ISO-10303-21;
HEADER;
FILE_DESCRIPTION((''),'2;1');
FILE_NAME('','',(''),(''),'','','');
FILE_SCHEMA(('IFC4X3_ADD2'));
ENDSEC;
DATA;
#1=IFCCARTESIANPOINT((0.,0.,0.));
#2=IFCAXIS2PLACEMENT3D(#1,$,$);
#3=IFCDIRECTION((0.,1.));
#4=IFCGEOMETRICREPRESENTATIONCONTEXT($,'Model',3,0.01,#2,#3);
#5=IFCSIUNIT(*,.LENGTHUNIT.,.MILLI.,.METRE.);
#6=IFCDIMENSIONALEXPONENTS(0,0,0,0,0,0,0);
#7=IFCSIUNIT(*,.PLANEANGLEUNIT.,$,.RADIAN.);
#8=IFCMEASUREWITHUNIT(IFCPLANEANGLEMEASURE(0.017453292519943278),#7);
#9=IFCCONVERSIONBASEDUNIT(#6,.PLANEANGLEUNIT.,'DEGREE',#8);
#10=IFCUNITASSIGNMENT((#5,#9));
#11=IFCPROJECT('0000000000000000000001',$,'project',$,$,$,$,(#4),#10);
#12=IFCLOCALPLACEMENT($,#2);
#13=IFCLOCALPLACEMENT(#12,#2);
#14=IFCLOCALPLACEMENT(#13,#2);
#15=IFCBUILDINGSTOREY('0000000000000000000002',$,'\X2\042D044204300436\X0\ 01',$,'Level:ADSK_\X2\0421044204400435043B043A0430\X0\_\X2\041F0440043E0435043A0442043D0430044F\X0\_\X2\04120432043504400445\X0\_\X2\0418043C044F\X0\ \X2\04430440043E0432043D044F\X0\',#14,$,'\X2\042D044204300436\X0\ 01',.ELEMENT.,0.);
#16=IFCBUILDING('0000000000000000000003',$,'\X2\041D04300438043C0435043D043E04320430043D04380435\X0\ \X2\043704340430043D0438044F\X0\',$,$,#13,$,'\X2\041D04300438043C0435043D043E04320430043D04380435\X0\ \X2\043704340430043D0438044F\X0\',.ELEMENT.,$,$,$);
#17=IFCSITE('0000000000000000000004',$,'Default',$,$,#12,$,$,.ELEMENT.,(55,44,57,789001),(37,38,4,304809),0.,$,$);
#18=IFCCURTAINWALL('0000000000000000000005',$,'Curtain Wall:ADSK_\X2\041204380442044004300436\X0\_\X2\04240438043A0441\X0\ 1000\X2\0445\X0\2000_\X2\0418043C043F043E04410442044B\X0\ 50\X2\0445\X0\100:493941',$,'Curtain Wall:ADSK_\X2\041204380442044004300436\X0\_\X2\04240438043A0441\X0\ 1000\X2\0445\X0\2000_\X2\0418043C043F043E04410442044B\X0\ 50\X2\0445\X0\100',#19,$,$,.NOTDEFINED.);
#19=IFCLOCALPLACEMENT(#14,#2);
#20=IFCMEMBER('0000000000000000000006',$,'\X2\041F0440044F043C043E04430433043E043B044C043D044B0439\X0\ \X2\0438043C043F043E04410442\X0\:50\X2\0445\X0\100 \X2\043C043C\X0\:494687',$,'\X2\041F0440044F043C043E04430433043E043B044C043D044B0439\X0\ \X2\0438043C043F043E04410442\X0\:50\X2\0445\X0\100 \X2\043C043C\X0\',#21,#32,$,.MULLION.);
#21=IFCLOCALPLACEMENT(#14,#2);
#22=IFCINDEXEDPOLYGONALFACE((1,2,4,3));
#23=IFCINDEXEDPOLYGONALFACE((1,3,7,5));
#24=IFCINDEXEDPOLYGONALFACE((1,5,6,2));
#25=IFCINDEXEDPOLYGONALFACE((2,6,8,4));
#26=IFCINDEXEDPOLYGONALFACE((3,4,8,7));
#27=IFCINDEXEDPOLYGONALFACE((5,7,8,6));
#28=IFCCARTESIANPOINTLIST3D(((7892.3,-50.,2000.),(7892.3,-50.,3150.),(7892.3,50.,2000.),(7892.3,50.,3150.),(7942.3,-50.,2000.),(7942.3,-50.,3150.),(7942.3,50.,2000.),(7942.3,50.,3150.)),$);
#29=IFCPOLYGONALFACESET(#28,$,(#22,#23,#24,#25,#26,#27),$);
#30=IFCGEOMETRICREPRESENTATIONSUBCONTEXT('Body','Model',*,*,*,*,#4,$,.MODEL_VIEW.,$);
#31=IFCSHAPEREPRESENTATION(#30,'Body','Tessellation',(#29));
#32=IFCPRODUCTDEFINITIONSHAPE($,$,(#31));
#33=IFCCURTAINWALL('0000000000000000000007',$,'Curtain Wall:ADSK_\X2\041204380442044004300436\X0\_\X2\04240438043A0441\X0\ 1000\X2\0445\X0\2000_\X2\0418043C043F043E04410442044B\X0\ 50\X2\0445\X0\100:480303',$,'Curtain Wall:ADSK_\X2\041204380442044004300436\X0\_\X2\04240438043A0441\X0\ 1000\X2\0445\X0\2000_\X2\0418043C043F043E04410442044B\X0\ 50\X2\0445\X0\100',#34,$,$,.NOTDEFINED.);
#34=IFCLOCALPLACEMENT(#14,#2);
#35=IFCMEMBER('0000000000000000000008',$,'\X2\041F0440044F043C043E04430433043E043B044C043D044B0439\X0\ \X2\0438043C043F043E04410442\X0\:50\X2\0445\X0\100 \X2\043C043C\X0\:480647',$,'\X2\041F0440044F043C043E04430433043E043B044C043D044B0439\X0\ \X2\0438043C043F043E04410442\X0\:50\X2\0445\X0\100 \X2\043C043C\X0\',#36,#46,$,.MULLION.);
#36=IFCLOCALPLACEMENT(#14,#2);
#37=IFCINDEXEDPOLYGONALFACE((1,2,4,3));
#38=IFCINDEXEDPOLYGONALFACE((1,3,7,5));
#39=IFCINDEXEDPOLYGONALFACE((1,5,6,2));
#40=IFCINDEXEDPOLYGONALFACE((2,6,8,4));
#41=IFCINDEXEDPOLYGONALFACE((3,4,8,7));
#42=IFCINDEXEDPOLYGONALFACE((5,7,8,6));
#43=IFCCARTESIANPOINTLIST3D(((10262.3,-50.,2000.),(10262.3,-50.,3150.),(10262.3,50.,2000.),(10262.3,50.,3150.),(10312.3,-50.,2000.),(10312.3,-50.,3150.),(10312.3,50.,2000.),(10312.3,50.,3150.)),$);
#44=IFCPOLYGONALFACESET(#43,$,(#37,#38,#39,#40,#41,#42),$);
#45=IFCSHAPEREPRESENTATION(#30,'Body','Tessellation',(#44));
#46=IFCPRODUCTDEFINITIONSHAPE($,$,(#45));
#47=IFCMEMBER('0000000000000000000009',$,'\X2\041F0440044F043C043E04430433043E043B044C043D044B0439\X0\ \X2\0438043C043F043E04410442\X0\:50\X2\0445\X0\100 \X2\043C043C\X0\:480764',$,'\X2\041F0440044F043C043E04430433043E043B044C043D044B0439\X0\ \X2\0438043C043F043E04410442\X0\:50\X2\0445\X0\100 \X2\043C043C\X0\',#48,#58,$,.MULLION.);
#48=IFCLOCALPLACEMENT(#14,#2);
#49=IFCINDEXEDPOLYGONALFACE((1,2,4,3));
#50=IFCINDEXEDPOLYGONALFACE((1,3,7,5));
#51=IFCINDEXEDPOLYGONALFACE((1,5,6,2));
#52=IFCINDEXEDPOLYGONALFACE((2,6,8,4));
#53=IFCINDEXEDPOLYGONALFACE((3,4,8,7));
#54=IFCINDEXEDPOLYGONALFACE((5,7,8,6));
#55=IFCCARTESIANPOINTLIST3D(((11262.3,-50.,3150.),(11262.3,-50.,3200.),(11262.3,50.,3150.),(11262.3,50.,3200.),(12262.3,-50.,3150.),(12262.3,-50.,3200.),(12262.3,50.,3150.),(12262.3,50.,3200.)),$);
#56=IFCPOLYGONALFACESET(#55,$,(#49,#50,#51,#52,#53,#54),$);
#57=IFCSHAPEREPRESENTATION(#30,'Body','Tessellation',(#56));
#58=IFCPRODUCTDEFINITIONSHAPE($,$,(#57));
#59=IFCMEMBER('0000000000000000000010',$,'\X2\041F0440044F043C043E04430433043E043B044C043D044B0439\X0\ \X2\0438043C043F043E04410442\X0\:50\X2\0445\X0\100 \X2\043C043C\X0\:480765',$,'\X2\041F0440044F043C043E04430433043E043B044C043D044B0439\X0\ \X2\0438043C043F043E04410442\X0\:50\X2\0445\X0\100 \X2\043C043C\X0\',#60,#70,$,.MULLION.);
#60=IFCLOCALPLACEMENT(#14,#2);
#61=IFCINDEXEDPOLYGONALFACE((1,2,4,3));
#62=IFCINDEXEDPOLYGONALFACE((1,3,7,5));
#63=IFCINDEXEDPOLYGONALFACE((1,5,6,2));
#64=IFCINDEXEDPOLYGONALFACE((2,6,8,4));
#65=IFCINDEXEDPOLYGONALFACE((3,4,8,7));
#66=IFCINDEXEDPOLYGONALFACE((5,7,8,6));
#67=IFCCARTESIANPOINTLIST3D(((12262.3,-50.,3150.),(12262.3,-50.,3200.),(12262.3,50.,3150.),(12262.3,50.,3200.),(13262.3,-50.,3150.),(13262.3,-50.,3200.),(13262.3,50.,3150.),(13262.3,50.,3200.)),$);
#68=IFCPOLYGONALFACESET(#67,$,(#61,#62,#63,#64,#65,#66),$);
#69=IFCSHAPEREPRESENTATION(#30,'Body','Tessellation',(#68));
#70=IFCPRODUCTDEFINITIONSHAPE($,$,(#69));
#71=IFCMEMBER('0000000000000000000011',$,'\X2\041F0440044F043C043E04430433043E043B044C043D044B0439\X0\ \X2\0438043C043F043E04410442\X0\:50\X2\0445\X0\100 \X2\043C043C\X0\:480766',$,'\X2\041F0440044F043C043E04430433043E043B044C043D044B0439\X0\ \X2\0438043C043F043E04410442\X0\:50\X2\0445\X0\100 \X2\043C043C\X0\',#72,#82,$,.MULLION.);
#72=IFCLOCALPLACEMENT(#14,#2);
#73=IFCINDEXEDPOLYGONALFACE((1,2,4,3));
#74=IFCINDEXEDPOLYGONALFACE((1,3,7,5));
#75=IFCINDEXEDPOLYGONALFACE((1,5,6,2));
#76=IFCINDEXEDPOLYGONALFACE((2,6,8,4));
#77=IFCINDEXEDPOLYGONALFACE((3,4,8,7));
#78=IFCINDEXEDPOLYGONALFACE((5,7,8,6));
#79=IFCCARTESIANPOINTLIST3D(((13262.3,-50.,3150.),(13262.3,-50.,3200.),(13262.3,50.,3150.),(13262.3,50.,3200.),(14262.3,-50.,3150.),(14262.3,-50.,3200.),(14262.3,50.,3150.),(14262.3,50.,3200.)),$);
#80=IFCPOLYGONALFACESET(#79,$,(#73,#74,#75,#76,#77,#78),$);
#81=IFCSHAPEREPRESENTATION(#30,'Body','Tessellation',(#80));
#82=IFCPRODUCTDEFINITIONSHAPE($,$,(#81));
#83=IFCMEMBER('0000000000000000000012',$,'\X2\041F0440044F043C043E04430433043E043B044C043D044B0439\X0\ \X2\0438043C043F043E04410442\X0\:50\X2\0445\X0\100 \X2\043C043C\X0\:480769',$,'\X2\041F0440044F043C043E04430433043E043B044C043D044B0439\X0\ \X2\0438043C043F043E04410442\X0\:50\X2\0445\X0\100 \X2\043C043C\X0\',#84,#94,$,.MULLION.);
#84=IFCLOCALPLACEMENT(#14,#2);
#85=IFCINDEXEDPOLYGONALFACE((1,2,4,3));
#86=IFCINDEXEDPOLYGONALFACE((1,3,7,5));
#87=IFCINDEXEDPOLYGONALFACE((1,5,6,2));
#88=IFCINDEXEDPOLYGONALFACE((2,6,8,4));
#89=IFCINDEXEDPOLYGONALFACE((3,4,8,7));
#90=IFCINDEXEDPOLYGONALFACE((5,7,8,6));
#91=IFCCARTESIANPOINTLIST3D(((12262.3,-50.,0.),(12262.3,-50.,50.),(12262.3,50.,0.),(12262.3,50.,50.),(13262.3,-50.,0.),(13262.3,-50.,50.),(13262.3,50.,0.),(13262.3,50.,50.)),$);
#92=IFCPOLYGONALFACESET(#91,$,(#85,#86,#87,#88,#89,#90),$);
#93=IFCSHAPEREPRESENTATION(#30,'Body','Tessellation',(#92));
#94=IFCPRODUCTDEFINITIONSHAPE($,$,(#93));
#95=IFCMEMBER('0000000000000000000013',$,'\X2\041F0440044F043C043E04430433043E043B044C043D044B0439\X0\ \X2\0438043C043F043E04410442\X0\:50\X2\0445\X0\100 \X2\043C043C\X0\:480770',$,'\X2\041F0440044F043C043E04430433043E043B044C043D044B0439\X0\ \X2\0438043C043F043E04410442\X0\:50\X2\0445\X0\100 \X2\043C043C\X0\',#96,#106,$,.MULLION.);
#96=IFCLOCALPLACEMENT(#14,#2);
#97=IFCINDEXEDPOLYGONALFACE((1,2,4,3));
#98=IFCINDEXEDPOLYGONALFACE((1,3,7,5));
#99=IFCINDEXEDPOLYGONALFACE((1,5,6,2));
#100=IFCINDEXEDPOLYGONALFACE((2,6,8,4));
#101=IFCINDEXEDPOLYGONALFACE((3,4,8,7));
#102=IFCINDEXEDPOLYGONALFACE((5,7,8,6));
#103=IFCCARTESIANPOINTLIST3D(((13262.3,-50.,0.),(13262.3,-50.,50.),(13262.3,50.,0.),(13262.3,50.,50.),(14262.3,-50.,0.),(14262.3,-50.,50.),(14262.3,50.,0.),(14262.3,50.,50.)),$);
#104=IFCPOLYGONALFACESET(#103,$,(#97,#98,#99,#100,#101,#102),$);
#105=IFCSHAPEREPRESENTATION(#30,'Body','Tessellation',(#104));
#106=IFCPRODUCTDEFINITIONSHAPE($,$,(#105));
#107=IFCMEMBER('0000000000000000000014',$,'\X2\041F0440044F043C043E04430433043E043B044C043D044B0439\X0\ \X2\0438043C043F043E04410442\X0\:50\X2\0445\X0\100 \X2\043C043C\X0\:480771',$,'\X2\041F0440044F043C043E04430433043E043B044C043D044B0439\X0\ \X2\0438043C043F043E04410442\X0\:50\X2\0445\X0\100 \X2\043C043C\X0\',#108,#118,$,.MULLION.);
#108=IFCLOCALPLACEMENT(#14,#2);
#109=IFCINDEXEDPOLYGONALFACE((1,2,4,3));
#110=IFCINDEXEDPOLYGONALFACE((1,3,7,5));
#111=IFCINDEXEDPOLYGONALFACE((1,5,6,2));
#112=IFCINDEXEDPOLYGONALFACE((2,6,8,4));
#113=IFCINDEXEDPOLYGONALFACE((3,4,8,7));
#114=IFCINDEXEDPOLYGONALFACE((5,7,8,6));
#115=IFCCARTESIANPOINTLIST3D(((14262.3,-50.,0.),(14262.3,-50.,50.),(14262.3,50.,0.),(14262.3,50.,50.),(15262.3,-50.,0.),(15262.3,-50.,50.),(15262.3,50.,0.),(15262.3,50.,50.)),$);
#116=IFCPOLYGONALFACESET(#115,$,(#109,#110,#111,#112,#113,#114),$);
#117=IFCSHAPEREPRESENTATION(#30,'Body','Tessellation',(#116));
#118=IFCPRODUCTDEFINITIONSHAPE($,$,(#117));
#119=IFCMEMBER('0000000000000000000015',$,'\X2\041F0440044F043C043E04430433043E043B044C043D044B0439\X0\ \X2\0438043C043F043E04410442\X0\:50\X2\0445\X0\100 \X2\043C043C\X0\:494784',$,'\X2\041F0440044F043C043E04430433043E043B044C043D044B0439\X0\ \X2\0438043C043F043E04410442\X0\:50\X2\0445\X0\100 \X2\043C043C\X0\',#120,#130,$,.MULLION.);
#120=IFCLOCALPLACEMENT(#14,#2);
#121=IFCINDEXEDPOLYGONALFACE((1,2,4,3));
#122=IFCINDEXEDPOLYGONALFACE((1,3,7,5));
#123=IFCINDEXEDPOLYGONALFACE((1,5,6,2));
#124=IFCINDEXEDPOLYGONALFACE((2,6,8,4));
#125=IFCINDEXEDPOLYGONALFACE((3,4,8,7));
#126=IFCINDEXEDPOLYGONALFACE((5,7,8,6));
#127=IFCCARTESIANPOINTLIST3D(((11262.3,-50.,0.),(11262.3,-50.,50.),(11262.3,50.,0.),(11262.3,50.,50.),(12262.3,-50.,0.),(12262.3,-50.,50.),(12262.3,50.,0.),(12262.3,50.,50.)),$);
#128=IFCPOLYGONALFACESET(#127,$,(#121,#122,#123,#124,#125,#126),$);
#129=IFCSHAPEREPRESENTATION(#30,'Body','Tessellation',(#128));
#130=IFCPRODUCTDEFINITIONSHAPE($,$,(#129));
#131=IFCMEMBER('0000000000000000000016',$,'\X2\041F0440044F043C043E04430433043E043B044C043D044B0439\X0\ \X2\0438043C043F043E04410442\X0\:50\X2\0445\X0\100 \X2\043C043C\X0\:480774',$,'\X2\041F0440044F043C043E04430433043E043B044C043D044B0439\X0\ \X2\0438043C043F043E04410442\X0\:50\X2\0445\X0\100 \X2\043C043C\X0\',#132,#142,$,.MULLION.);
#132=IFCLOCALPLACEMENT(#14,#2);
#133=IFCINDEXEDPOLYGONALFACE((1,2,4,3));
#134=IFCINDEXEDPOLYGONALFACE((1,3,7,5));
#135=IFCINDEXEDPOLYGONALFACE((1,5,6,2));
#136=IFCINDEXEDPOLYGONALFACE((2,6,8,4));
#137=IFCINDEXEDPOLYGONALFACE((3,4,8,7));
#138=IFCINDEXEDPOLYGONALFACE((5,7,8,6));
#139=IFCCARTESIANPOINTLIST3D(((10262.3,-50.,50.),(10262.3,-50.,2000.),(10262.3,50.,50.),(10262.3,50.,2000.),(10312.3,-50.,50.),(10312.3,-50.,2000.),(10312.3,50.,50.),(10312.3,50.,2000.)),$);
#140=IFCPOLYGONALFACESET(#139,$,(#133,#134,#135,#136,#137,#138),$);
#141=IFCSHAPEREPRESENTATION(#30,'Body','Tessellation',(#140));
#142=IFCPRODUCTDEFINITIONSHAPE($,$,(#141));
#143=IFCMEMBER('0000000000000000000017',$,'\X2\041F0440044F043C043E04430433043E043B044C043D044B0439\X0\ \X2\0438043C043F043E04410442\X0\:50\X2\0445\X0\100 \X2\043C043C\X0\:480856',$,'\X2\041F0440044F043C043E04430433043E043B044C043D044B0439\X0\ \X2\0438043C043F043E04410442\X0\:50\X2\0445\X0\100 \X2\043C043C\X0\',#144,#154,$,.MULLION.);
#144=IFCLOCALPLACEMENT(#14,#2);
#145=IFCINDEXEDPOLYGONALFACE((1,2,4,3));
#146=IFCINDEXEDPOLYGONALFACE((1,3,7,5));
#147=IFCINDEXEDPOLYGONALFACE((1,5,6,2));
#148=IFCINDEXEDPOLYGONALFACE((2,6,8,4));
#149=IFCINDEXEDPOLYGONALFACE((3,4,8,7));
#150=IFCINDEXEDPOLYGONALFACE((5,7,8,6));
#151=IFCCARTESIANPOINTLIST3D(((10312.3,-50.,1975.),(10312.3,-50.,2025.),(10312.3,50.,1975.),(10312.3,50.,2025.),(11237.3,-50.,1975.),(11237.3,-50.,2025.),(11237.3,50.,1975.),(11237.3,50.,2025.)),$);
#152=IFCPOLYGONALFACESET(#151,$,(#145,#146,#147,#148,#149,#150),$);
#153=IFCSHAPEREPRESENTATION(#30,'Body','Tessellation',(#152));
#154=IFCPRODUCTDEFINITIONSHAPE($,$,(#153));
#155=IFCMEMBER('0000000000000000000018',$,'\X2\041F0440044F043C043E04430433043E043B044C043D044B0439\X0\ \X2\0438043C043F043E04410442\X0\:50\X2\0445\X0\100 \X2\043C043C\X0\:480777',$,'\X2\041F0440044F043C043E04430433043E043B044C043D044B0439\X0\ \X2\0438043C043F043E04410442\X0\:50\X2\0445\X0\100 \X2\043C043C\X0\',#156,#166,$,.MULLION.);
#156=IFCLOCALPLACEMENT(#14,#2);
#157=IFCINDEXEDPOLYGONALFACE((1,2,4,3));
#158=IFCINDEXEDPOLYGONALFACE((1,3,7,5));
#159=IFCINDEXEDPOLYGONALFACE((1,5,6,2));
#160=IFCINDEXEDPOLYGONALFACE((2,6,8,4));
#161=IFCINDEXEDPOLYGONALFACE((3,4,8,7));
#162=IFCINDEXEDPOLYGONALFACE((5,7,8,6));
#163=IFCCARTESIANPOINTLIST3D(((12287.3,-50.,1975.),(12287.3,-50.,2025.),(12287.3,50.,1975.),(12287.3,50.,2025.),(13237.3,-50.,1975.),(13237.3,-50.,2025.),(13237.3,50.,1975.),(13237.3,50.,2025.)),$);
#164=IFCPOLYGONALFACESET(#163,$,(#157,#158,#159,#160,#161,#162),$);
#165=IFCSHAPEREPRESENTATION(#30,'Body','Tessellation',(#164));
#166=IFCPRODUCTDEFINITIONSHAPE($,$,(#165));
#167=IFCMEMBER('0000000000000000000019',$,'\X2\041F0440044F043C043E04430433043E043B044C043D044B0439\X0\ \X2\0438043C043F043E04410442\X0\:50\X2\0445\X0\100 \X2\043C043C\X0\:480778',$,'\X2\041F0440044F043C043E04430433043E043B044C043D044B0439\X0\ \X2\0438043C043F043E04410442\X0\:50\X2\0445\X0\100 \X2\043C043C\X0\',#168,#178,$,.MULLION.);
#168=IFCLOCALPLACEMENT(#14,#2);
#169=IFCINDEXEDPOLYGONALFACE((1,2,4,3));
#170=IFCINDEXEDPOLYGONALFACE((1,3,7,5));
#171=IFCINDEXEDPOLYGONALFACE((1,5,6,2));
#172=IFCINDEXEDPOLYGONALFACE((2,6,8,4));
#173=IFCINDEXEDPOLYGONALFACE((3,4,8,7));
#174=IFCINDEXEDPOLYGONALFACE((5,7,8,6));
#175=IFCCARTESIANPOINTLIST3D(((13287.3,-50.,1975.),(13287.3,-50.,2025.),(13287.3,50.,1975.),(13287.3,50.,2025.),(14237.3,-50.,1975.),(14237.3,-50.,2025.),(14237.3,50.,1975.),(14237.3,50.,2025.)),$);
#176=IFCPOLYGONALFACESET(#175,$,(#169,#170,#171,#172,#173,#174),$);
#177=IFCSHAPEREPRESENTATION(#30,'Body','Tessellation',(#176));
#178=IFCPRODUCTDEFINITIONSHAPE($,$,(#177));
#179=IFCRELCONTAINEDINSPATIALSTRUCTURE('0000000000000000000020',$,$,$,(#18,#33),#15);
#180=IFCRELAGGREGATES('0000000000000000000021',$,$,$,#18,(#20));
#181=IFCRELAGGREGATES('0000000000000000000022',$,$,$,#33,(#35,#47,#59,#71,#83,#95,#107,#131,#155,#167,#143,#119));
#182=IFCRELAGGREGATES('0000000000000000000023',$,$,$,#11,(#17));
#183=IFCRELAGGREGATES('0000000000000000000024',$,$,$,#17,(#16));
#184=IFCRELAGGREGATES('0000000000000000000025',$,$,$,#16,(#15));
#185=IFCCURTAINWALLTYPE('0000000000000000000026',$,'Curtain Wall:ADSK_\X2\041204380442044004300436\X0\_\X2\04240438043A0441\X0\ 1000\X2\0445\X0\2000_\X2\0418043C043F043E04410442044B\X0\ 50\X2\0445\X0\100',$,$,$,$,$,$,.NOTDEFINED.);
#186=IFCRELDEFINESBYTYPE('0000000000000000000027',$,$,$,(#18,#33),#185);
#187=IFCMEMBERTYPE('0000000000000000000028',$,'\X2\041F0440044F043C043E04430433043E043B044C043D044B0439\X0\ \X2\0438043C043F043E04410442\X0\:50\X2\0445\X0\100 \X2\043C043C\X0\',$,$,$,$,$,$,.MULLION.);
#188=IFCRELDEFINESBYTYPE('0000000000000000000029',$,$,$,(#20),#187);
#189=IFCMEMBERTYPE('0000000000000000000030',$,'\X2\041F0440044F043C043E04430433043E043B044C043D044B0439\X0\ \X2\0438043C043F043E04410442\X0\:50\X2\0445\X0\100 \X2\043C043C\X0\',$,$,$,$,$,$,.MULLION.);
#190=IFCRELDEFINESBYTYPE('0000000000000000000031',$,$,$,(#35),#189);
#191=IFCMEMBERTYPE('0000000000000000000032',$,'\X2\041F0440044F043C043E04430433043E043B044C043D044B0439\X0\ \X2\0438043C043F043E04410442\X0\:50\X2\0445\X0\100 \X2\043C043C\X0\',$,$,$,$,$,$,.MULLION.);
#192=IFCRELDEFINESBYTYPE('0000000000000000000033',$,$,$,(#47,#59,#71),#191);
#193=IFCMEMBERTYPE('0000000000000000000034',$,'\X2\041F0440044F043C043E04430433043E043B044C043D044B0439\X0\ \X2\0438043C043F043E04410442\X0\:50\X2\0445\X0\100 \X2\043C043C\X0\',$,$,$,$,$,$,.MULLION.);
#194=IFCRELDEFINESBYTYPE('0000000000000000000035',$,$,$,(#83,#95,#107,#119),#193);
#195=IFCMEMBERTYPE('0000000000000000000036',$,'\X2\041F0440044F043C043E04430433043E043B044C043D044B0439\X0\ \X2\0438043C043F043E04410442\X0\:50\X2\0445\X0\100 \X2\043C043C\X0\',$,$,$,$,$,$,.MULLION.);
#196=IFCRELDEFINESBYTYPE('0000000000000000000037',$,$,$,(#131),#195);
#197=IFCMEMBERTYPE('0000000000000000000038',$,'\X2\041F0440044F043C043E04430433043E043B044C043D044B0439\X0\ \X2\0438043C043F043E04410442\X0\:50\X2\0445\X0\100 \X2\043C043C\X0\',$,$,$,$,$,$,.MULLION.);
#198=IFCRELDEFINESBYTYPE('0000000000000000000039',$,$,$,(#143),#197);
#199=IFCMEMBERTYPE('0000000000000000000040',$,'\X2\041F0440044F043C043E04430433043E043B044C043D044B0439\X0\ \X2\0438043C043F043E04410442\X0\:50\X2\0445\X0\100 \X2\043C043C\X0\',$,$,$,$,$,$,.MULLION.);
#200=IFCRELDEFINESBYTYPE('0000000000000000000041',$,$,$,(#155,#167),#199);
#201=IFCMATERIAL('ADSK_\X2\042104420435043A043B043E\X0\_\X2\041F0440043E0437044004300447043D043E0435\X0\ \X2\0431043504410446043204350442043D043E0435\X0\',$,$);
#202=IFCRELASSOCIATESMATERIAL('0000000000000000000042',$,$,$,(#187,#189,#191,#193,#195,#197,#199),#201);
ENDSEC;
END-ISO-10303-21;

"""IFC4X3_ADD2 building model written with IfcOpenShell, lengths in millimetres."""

from ifc_helpers import new_model, entity, si_unit, converted_unit, direction, frame, frame_2d, origin, place, context, subcontext, project, spatial, rectangle, extrude, source, transform, mapped, material, material_profile, profile_set, type_object, type_shapes, element, aggregate, save


model = new_model("IFC4X3_ADD2")

# Units and contexts
model_context = context("Model", 3, precision=0.01, world=origin(), true_north=direction((0.0, 1.0)))
body_context = subcontext(model_context, "Body", "Model", "MODEL_VIEW")
ifc_project = project(units=[si_unit("LENGTHUNIT", "METRE", prefix="MILLI"), converted_unit("PLANEANGLEUNIT", "DEGREE", entity("IfcPlaneAngleMeasure", 0.017453292519943278), si_unit("PLANEANGLEUNIT", "RADIAN"), dimensions=[0, 0, 0, 0, 0, 0, 0])], contexts=[model_context])

# Site, building, storey
site_placement = place(None, origin())
site = spatial("IfcSite", under=ifc_project, at=site_placement, Name="Default", CompositionType="ELEMENT", RefLatitude=(55, 44, 57, 789001), RefLongitude=(37, 38, 4, 304809), RefElevation=0.0)
building_placement = place(site_placement, origin())
building = spatial("IfcBuilding", under=site, at=building_placement, Name="Наименование здания", LongName="Наименование здания", CompositionType="ELEMENT")
storey_placement = place(building_placement, origin())
storey = spatial("IfcBuildingStorey", under=building, at=storey_placement, Name="Этаж 01", ObjectType="Level:ADSK_Стрелка_Проектная_Вверх_Имя уровня", LongName="Этаж 01", CompositionType="ELEMENT", Elevation=0.0)

# Curtain wall, member
curtain_wall_type = type_object("IfcCurtainWallType", Name="Curtain Wall:ADSK_Витраж_Фикс 1000х2000_Импосты 50х100", PredefinedType="NOTDEFINED")
curtain_wall_1_placement = place(storey_placement, origin())
curtain_wall_1 = element("IfcCurtainWall", 1, at=curtain_wall_1_placement, inside=storey, type_object=curtain_wall_type, Name="Curtain Wall:ADSK_Витраж_Фикс 1000х2000_Импосты 50х100:493941", ObjectType="Curtain Wall:ADSK_Витраж_Фикс 1000х2000_Импосты 50х100", PredefinedType="NOTDEFINED")
ifc_material_1 = material(Name="ADSK_Стекло_Прозрачное бесцветное")
ifc_material_profile = material_profile(ifc_material_1, rectangle(XDim=50.0, YDim=100.0, at=frame_2d((0.0, 0.0), x_axis=(1.0, 0.0))), Name="50х100 мм")
ifc_profile_set = profile_set([ifc_material_profile], Name="50х100 мм")
member_type_1 = type_object("IfcMemberType", Name="Прямоугольный импост:50х100 мм", PredefinedType="MULLION", material=ifc_profile_set)
shared_shape_1 = source(origin(), body_context, "Body", "SweptSolid", [
    extrude(rectangle(XDim=50.0, YDim=100.0, at=frame_2d((0.0, 0.0), x_axis=(1.0, 0.0))), frame((-25.0, 0.0, -1150.0), z_axis=(0.0, 0.0, 1.0), x_axis=(-1.0, 0.0, 0.0)), (0.0, 0.0, 1.0), 1150.0),
])
type_shapes(member_type_1, [shared_shape_1])
member_1_placement = place(curtain_wall_1_placement, frame((7942.3, 0.0, 2000.0), z_axis=(0.0, 0.0, -1.0), x_axis=(1.0, 0.0, 0.0)))
member_1 = element("IfcMember", 2, at=member_1_placement, type_object=member_type_1, Name="Прямоугольный импост:50х100 мм:494687", ObjectType="Прямоугольный импост:50х100 мм", PredefinedType="MULLION", context=body_context, shape_type="MappedRepresentation", body=[
    mapped(shared_shape_1, transform((0.0, 0.0, 0.0), scale=1.0)),
])

# Curtain wall, members
curtain_wall_2_placement = place(storey_placement, origin())
curtain_wall_2 = element("IfcCurtainWall", 3, at=curtain_wall_2_placement, inside=storey, type_object=curtain_wall_type, Name="Curtain Wall:ADSK_Витраж_Фикс 1000х2000_Импосты 50х100:480303", ObjectType="Curtain Wall:ADSK_Витраж_Фикс 1000х2000_Импосты 50х100", PredefinedType="NOTDEFINED")
member_type_2 = type_object("IfcMemberType", Name="Прямоугольный импост:50х100 мм", PredefinedType="MULLION", material=ifc_profile_set)
shared_shape_2 = source(origin(), body_context, "Body", "SweptSolid", [
    extrude(rectangle(XDim=50.0, YDim=100.0, at=frame_2d((0.0, 0.0), x_axis=(1.0, 0.0))), frame((-25.0, 0.0, -1150.0), z_axis=(0.0, 0.0, 1.0), x_axis=(-1.0, 0.0, 0.0)), (0.0, 0.0, 1.0), 1150.0),
])
type_shapes(member_type_2, [shared_shape_2])
member_2_placement = place(curtain_wall_2_placement, frame((10262.3, 0.0, 3150.0), z_axis=(0.0, 0.0, 1.0), x_axis=(-1.0, 0.0, 0.0)))
member_2 = element("IfcMember", 4, at=member_2_placement, type_object=member_type_2, Name="Прямоугольный импост:50х100 мм:480647", ObjectType="Прямоугольный импост:50х100 мм", PredefinedType="MULLION", context=body_context, shape_type="MappedRepresentation", body=[
    mapped(shared_shape_2, transform((0.0, 0.0, 0.0), scale=1.0)),
])
member_type_3 = type_object("IfcMemberType", Name="Прямоугольный импост:50х100 мм", PredefinedType="MULLION", material=ifc_profile_set)
shared_shape_3 = source(origin(), body_context, "Body", "SweptSolid", [
    extrude(rectangle(XDim=50.0, YDim=100.0, at=frame_2d((0.0, 0.0), x_axis=(1.0, 0.0))), frame((-25.0, 0.0, -1000.0), z_axis=(0.0, 0.0, 1.0), x_axis=(-1.0, 0.0, 0.0)), (0.0, 0.0, 1.0), 1000.0),
])
type_shapes(member_type_3, [shared_shape_3])
member_3_placement = place(curtain_wall_2_placement, frame((12262.3, 0.0, 3200.0), z_axis=(1.0, 0.0, 0.0), x_axis=(0.0, 0.0, 1.0)))
member_3 = element("IfcMember", 5, at=member_3_placement, type_object=member_type_3, Name="Прямоугольный импост:50х100 мм:480764", ObjectType="Прямоугольный импост:50х100 мм", PredefinedType="MULLION", context=body_context, shape_type="MappedRepresentation", body=[
    mapped(shared_shape_3, transform((0.0, 0.0, 0.0), scale=1.0)),
])
member_4_placement = place(curtain_wall_2_placement, frame((13262.3, 0.0, 3200.0), z_axis=(1.0, 0.0, 0.0), x_axis=(0.0, 0.0, 1.0)))
member_4 = element("IfcMember", 6, at=member_4_placement, type_object=member_type_3, Name="Прямоугольный импост:50х100 мм:480765", ObjectType="Прямоугольный импост:50х100 мм", PredefinedType="MULLION", context=body_context, shape_type="MappedRepresentation", body=[
    mapped(shared_shape_3, transform((0.0, 0.0, 0.0), scale=1.0)),
])
member_5_placement = place(curtain_wall_2_placement, frame((14262.3, 0.0, 3200.0), z_axis=(1.0, 0.0, 0.0), x_axis=(0.0, 0.0, 1.0)))
member_5 = element("IfcMember", 7, at=member_5_placement, type_object=member_type_3, Name="Прямоугольный импост:50х100 мм:480766", ObjectType="Прямоугольный импост:50х100 мм", PredefinedType="MULLION", context=body_context, shape_type="MappedRepresentation", body=[
    mapped(shared_shape_3, transform((0.0, 0.0, 0.0), scale=1.0)),
])
member_type_4 = type_object("IfcMemberType", Name="Прямоугольный импост:50х100 мм", PredefinedType="MULLION", material=ifc_profile_set)
shared_shape_4 = source(origin(), body_context, "Body", "SweptSolid", [
    extrude(rectangle(XDim=50.0, YDim=100.0, at=frame_2d((0.0, 0.0), x_axis=(1.0, 0.0))), frame((-25.0, 0.0, -1000.0), z_axis=(0.0, 0.0, 1.0), x_axis=(-1.0, 0.0, 0.0)), (0.0, 0.0, 1.0), 1000.0),
])
type_shapes(member_type_4, [shared_shape_4])
member_6_placement = place(curtain_wall_2_placement, frame((12262.3, 0.0, 0.0), z_axis=(-1.0, 0.0, 0.0), x_axis=(0.0, 0.0, -1.0)))
member_6 = element("IfcMember", 8, at=member_6_placement, type_object=member_type_4, Name="Прямоугольный импост:50х100 мм:480769", ObjectType="Прямоугольный импост:50х100 мм", PredefinedType="MULLION", context=body_context, shape_type="MappedRepresentation", body=[
    mapped(shared_shape_4, transform((0.0, 0.0, 0.0), scale=1.0)),
])
member_7_placement = place(curtain_wall_2_placement, frame((13262.3, 0.0, 0.0), z_axis=(-1.0, 0.0, 0.0), x_axis=(0.0, 0.0, -1.0)))
member_7 = element("IfcMember", 9, at=member_7_placement, type_object=member_type_4, Name="Прямоугольный импост:50х100 мм:480770", ObjectType="Прямоугольный импост:50х100 мм", PredefinedType="MULLION", context=body_context, shape_type="MappedRepresentation", body=[
    mapped(shared_shape_4, transform((0.0, 0.0, 0.0), scale=1.0)),
])
member_8_placement = place(curtain_wall_2_placement, frame((14262.3, 0.0, 0.0), z_axis=(-1.0, 0.0, 0.0), x_axis=(0.0, 0.0, -1.0)))
member_8 = element("IfcMember", 10, at=member_8_placement, type_object=member_type_4, Name="Прямоугольный импост:50х100 мм:480771", ObjectType="Прямоугольный импост:50х100 мм", PredefinedType="MULLION", context=body_context, shape_type="MappedRepresentation", body=[
    mapped(shared_shape_4, transform((0.0, 0.0, 0.0), scale=1.0)),
])
member_9_placement = place(curtain_wall_2_placement, frame((11262.3, 0.0, 0.0), z_axis=(-1.0, 0.0, 0.0), x_axis=(0.0, 0.0, -1.0)))
member_9 = element("IfcMember", 11, at=member_9_placement, type_object=member_type_4, Name="Прямоугольный импост:50х100 мм:494784", ObjectType="Прямоугольный импост:50х100 мм", PredefinedType="MULLION", context=body_context, shape_type="MappedRepresentation", body=[
    mapped(shared_shape_4, transform((0.0, 0.0, 0.0), scale=1.0)),
])
member_type_5 = type_object("IfcMemberType", Name="Прямоугольный импост:50х100 мм", PredefinedType="MULLION", material=ifc_profile_set)
shared_shape_5 = source(origin(), body_context, "Body", "SweptSolid", [
    extrude(rectangle(XDim=50.0, YDim=100.0, at=frame_2d((0.0, 0.0), x_axis=(1.0, 0.0))), frame((-25.0, 0.0, -1950.0), z_axis=(0.0, 0.0, 1.0), x_axis=(-1.0, 0.0, 0.0)), (0.0, 0.0, 1.0), 1950.0),
])
type_shapes(member_type_5, [shared_shape_5])
member_10_placement = place(curtain_wall_2_placement, frame((10262.3, 0.0, 2000.0), z_axis=(0.0, 0.0, 1.0), x_axis=(-1.0, 0.0, 0.0)))
member_10 = element("IfcMember", 12, at=member_10_placement, type_object=member_type_5, Name="Прямоугольный импост:50х100 мм:480774", ObjectType="Прямоугольный импост:50х100 мм", PredefinedType="MULLION", context=body_context, shape_type="MappedRepresentation", body=[
    mapped(shared_shape_5, transform((0.0, 0.0, 0.0), scale=1.0)),
])
member_type_6 = type_object("IfcMemberType", Name="Прямоугольный импост:50х100 мм", PredefinedType="MULLION", material=ifc_profile_set)
shared_shape_6 = source(origin(), body_context, "Body", "SweptSolid", [
    extrude(rectangle(XDim=50.0, YDim=100.0, at=frame_2d((0.0, 0.0), x_axis=(1.0, 0.0))), frame((0.0, 0.0, -925.0), z_axis=(0.0, 0.0, 1.0), x_axis=(-1.0, 0.0, 0.0)), (0.0, 0.0, 1.0), 925.0),
])
type_shapes(member_type_6, [shared_shape_6])
member_11_placement = place(curtain_wall_2_placement, frame((11237.3, 0.0, 2000.0), z_axis=(1.0, 0.0, 0.0), x_axis=(0.0, 0.0, 1.0)))
member_11 = element("IfcMember", 13, at=member_11_placement, type_object=member_type_6, Name="Прямоугольный импост:50х100 мм:480856", ObjectType="Прямоугольный импост:50х100 мм", PredefinedType="MULLION", context=body_context, shape_type="MappedRepresentation", body=[
    mapped(shared_shape_6, transform((0.0, 0.0, 0.0), scale=1.0)),
])
member_type_7 = type_object("IfcMemberType", Name="Прямоугольный импост:50х100 мм", PredefinedType="MULLION", material=ifc_profile_set)
shared_shape_7 = source(origin(), body_context, "Body", "SweptSolid", [
    extrude(rectangle(XDim=50.0, YDim=100.0, at=frame_2d((0.0, 0.0), x_axis=(1.0, 0.0))), frame((0.0, 0.0, -950.0), z_axis=(0.0, 0.0, 1.0), x_axis=(-1.0, 0.0, 0.0)), (0.0, 0.0, 1.0), 950.0),
])
type_shapes(member_type_7, [shared_shape_7])
member_12_placement = place(curtain_wall_2_placement, frame((13237.3, 0.0, 2000.0), z_axis=(1.0, 0.0, 0.0), x_axis=(0.0, 0.0, 1.0)))
member_12 = element("IfcMember", 14, at=member_12_placement, type_object=member_type_7, Name="Прямоугольный импост:50х100 мм:480777", ObjectType="Прямоугольный импост:50х100 мм", PredefinedType="MULLION", context=body_context, shape_type="MappedRepresentation", body=[
    mapped(shared_shape_7, transform((0.0, 0.0, 0.0), scale=1.0)),
])
member_13_placement = place(curtain_wall_2_placement, frame((14237.3, 0.0, 2000.0), z_axis=(1.0, 0.0, 0.0), x_axis=(0.0, 0.0, 1.0)))
member_13 = element("IfcMember", 15, at=member_13_placement, type_object=member_type_7, Name="Прямоугольный импост:50х100 мм:480778", ObjectType="Прямоугольный импост:50х100 мм", PredefinedType="MULLION", context=body_context, shape_type="MappedRepresentation", body=[
    mapped(shared_shape_7, transform((0.0, 0.0, 0.0), scale=1.0)),
])

aggregate(curtain_wall_1, [member_1])

aggregate(curtain_wall_2, [member_2, member_3, member_4, member_5, member_6, member_7, member_8, member_10, member_12, member_13, member_11, member_9])

save(model, "model.ifc")
